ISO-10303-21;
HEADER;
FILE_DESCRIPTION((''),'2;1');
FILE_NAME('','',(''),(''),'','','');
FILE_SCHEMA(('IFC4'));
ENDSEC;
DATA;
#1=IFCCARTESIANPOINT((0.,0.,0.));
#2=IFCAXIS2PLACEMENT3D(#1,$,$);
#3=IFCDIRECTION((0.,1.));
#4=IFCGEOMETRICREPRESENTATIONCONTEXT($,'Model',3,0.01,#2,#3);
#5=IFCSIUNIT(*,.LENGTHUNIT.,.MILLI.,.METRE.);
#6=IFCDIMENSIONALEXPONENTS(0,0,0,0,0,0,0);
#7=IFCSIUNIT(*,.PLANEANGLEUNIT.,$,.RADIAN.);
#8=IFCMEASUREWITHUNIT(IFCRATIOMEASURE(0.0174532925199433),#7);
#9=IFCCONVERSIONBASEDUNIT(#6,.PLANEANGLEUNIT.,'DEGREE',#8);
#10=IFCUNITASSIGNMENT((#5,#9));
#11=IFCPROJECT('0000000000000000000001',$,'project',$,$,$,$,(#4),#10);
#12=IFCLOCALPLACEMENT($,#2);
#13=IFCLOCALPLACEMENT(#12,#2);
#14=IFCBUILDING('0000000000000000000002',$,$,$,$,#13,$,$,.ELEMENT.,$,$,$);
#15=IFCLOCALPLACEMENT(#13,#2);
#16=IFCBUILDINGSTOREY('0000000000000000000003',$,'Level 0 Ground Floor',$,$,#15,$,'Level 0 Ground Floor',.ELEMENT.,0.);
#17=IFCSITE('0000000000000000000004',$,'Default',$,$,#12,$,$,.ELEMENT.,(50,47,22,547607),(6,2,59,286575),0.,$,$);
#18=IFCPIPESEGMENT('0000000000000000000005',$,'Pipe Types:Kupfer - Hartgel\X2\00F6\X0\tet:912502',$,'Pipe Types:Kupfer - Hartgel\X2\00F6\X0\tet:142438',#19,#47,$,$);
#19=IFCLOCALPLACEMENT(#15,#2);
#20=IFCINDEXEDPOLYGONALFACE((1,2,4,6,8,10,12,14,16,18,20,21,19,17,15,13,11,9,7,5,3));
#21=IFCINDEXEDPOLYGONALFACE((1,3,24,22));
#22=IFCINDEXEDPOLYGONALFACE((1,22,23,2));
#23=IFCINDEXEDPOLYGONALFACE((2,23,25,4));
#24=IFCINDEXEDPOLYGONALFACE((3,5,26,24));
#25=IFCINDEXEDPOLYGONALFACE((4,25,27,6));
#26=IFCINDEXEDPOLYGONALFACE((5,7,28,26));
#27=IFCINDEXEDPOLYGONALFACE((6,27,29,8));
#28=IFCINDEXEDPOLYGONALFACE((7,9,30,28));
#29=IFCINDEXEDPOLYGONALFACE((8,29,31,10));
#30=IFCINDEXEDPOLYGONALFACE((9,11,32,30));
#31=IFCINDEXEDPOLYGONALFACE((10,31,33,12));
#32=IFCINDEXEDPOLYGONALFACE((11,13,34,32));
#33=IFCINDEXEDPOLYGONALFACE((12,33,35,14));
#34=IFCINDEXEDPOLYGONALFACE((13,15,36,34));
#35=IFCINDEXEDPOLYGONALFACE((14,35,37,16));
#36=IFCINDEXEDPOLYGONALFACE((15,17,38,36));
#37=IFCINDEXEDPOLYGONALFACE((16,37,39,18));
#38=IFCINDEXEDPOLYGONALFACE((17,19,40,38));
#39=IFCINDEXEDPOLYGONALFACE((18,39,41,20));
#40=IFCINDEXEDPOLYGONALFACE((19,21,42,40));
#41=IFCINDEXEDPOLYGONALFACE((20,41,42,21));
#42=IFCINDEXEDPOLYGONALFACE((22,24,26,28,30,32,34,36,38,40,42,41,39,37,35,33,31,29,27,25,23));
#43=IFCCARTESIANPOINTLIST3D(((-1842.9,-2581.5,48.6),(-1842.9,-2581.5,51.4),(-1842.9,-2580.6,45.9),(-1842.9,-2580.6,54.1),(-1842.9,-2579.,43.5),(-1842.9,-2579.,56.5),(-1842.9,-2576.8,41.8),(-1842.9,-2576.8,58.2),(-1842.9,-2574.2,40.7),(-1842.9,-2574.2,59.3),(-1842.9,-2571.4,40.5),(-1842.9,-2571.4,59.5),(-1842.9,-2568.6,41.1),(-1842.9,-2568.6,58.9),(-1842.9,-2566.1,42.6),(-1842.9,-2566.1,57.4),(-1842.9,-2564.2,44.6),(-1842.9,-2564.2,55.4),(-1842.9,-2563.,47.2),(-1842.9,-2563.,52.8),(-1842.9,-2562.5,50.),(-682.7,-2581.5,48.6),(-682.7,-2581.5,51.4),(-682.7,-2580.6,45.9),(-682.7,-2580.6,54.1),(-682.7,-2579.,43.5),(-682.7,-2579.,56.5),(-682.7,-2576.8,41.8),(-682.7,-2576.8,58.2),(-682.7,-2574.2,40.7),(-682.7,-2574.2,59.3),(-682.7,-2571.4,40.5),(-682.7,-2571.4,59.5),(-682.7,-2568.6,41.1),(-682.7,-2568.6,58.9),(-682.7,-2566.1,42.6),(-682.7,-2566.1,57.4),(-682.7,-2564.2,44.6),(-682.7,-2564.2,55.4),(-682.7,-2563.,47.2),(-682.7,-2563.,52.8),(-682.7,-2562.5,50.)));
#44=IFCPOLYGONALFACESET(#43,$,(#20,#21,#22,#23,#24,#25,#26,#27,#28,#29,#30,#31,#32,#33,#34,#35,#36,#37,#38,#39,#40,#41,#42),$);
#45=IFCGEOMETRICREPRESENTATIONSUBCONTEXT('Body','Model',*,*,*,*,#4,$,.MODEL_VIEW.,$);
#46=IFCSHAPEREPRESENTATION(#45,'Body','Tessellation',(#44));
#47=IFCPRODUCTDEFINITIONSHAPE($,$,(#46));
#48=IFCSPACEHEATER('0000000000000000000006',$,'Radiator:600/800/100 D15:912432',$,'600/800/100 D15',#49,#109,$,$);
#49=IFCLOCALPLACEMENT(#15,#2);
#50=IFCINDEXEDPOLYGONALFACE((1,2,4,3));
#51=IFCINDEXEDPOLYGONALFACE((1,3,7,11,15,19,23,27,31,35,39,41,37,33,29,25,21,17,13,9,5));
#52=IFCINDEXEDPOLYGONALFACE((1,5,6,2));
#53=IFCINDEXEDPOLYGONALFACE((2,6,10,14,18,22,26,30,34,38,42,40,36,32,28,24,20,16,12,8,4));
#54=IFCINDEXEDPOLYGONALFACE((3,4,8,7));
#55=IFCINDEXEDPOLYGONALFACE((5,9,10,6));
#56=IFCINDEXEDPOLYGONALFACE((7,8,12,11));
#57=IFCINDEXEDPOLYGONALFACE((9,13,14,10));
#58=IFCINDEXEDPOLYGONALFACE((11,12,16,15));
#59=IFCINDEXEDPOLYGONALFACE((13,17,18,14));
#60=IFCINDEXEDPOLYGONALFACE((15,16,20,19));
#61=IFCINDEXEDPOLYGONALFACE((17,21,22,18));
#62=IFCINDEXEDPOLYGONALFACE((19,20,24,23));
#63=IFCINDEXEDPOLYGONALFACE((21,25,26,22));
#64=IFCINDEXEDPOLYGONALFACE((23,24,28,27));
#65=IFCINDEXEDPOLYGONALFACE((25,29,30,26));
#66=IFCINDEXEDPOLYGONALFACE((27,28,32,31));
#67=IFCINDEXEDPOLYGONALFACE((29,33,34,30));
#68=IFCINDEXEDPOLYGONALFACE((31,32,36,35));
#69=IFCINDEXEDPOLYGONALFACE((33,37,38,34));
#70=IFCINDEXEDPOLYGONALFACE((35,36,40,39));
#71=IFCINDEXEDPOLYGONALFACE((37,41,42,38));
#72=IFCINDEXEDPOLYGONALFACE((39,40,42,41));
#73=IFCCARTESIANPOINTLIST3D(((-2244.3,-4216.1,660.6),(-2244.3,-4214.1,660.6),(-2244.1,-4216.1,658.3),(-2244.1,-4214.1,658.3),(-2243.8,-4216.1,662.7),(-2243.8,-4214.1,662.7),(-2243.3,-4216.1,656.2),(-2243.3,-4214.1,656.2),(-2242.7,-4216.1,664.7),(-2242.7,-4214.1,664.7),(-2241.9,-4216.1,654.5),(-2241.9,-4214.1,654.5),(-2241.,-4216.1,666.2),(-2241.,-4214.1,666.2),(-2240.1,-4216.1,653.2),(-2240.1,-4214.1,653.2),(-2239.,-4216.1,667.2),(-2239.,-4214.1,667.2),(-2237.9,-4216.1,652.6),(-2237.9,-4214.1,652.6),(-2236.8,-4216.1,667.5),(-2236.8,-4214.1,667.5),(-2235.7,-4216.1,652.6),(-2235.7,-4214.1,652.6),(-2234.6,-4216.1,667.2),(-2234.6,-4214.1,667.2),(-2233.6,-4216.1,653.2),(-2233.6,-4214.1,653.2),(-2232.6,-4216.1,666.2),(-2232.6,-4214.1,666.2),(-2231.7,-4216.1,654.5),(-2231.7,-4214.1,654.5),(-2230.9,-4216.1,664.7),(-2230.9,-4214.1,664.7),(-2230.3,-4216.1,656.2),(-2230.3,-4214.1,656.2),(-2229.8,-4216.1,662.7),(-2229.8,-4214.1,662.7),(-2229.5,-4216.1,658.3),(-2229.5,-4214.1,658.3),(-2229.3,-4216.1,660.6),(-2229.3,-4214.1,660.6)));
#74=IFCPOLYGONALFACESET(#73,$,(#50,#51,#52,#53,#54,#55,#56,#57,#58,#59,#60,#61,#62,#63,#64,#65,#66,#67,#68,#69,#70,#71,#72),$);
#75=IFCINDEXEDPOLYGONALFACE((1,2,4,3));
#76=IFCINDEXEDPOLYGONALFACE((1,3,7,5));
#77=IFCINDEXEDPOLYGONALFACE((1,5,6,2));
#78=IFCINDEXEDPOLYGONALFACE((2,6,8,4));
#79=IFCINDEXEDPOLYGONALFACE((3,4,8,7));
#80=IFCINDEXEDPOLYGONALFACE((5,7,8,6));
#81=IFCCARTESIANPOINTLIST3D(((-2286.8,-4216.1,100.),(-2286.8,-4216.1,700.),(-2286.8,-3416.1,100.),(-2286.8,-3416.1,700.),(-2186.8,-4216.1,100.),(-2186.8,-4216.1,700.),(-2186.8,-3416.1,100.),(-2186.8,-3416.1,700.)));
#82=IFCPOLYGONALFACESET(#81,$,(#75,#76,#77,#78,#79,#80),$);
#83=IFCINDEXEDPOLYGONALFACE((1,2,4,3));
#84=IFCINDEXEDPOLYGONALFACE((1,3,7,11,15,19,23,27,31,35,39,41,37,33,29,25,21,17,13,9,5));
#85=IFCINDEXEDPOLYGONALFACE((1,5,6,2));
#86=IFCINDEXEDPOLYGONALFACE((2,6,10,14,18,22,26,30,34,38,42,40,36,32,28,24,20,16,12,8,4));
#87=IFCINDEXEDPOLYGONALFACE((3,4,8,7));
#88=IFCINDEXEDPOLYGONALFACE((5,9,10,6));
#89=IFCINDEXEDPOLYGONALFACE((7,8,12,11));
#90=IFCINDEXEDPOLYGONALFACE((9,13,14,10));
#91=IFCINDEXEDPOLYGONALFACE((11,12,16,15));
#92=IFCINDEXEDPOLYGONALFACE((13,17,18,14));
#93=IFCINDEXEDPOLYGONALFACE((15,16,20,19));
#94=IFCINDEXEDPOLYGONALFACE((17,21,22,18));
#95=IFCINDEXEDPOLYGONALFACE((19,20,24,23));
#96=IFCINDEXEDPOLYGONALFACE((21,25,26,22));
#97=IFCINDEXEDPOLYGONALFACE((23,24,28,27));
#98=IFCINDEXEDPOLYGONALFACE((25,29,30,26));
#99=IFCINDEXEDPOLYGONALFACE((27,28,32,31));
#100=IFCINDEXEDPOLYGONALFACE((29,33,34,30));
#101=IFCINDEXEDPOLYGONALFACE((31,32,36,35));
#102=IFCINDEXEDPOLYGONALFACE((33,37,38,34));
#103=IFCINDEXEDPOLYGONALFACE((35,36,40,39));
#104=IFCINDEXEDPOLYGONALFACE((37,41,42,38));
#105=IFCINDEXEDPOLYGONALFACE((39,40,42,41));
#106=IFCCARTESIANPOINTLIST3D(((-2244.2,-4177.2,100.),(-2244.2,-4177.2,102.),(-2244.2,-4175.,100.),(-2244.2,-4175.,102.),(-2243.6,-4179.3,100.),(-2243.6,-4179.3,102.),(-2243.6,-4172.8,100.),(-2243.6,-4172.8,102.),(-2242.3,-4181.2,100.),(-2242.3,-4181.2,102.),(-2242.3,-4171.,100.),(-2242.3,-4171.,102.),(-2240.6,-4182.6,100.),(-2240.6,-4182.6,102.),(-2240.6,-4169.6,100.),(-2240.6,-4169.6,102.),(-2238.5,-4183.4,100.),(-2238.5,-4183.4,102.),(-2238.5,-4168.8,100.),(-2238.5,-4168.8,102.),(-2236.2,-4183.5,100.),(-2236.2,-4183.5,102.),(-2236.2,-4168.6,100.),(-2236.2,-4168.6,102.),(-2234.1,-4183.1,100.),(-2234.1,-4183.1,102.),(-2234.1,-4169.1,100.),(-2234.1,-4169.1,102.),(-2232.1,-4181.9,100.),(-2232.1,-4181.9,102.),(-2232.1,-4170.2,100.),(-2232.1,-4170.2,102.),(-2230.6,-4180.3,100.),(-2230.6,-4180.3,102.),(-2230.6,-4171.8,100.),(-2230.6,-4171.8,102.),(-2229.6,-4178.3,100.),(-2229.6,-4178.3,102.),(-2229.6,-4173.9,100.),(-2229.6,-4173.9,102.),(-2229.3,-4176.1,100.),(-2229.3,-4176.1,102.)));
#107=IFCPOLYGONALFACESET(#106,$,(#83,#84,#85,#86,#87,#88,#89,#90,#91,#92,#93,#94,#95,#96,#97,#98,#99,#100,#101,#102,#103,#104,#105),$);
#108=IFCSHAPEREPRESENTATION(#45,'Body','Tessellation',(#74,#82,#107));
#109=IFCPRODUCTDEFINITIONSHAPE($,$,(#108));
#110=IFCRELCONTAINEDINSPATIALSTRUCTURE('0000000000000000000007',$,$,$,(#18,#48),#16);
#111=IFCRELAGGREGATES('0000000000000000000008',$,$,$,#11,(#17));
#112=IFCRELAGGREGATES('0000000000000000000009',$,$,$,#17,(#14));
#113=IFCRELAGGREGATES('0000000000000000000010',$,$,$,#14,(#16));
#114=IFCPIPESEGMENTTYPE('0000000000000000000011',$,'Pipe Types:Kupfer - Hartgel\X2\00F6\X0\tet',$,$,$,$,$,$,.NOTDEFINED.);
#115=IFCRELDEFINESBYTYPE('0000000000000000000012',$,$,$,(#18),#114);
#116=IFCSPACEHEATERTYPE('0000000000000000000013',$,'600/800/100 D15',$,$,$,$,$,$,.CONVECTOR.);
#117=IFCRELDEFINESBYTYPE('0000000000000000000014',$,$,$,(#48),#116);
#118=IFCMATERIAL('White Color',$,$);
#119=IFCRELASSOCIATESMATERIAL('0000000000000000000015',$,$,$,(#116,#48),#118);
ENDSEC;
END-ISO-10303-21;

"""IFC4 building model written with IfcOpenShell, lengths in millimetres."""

from ifc_helpers import new_model, entity, si_unit, converted_unit, direction, frame, frame_2d, origin, place, context, subcontext, project, spatial, rectangle, circle, extrude, source, transform, mapped, material, type_object, type_shapes, element, save


model = new_model("IFC4")

# Units and contexts
model_context = context("Model", 3, precision=0.01, world=origin(), true_north=direction((0.0, 1.0)))
body_context = subcontext(model_context, "Body", "Model", "MODEL_VIEW")
ifc_project = project(units=[si_unit("LENGTHUNIT", "METRE", prefix="MILLI"), converted_unit("PLANEANGLEUNIT", "DEGREE", entity("IfcRatioMeasure", 0.0174532925199433), si_unit("PLANEANGLEUNIT", "RADIAN"), dimensions=[0, 0, 0, 0, 0, 0, 0])], contexts=[model_context])

# Site, building, storey
site_placement = place(None, origin())
site = spatial("IfcSite", under=ifc_project, at=site_placement, Name="Default", CompositionType="ELEMENT", RefLatitude=(50, 47, 22, 547607), RefLongitude=(6, 2, 59, 286575), RefElevation=0.0)
building_placement = place(site_placement, origin())
building = spatial("IfcBuilding", under=site, at=building_placement, CompositionType="ELEMENT")
storey_placement = place(building_placement, origin())
storey = spatial("IfcBuildingStorey", under=building, at=storey_placement, Name="Level 0 Ground Floor", LongName="Level 0 Ground Floor", CompositionType="ELEMENT", Elevation=0.0)

# Pipe segment
pipe_segment_type = type_object("IfcPipeSegmentType", Name="Pipe Types:Kupfer - Hartgelötet", PredefinedType="NOTDEFINED")
pipe_segment_1_placement = place(storey_placement, frame((-1842.9, -2583.2, 38.9)))
element("IfcPipeSegment", 1, at=pipe_segment_1_placement, inside=storey, type_object=pipe_segment_type, Name="Pipe Types:Kupfer - Hartgelötet:912502", ObjectType="Pipe Types:Kupfer - Hartgelötet:142438", context=body_context, shape_type="SweptSolid", body=[
    extrude(circle(Radius=9.5, at=frame_2d((0.0, 0.0), x_axis=(1.0, 0.0))), frame((0.0, 11.1, 11.1), z_axis=(1.0, 0.000001, 0.0), x_axis=(-0.000001, 1.0, 0.0)), (0.0, 0.0, 1.0), 1160.2),
])

# Space heater
ifc_material = material(Name="White Color")
space_heater_type = type_object("IfcSpaceHeaterType", Name="600/800/100 D15", PredefinedType="CONVECTOR", material=ifc_material)
shared_shape_1 = source(origin(), body_context, "Body", "SweptSolid", [
    extrude(circle(Radius=7.5, at=frame_2d((0.0, 0.0), x_axis=(1.0, 0.0))), frame((798.0, 50.0, 560.0), z_axis=(1.0, 0.0, 0.0), x_axis=(0.0, 0.0, 1.0)), (0.0, 0.0, 1.0), 2.0),
    extrude(rectangle(XDim=100.0, YDim=800.0, at=frame_2d((0.0, 0.0), x_axis=(1.0, 0.0))), frame((400.0, 50.0, 0.0), z_axis=(0.0, 0.0, 1.0), x_axis=(0.0, 1.0, 0.0)), (0.0, 0.0, 1.0), 600.0),
    extrude(circle(Radius=7.5, at=frame_2d((0.0, 0.0), x_axis=(1.0, 0.0))), frame((760.0, 50.0, 0.0), z_axis=(0.0, 0.0, 1.0), x_axis=(0.0, 1.0, 0.0)), (0.0, 0.0, 1.0), 2.0),
])
type_shapes(space_heater_type, [shared_shape_1])
space_heater_placement = place(storey_placement, frame((-2286.8, -3416.1, 100.0), z_axis=(0.0, 0.0, 1.0), x_axis=(0.000017, -1.0, 0.0)))
element("IfcSpaceHeater", 2, at=space_heater_placement, inside=storey, type_object=space_heater_type, material=ifc_material, Name="Radiator:600/800/100 D15:912432", ObjectType="600/800/100 D15", context=body_context, shape_type="MappedRepresentation", body=[
    mapped(shared_shape_1, transform((0.0, 0.0, 0.0), scale=1.0)),
])

save(model, "model.ifc")
